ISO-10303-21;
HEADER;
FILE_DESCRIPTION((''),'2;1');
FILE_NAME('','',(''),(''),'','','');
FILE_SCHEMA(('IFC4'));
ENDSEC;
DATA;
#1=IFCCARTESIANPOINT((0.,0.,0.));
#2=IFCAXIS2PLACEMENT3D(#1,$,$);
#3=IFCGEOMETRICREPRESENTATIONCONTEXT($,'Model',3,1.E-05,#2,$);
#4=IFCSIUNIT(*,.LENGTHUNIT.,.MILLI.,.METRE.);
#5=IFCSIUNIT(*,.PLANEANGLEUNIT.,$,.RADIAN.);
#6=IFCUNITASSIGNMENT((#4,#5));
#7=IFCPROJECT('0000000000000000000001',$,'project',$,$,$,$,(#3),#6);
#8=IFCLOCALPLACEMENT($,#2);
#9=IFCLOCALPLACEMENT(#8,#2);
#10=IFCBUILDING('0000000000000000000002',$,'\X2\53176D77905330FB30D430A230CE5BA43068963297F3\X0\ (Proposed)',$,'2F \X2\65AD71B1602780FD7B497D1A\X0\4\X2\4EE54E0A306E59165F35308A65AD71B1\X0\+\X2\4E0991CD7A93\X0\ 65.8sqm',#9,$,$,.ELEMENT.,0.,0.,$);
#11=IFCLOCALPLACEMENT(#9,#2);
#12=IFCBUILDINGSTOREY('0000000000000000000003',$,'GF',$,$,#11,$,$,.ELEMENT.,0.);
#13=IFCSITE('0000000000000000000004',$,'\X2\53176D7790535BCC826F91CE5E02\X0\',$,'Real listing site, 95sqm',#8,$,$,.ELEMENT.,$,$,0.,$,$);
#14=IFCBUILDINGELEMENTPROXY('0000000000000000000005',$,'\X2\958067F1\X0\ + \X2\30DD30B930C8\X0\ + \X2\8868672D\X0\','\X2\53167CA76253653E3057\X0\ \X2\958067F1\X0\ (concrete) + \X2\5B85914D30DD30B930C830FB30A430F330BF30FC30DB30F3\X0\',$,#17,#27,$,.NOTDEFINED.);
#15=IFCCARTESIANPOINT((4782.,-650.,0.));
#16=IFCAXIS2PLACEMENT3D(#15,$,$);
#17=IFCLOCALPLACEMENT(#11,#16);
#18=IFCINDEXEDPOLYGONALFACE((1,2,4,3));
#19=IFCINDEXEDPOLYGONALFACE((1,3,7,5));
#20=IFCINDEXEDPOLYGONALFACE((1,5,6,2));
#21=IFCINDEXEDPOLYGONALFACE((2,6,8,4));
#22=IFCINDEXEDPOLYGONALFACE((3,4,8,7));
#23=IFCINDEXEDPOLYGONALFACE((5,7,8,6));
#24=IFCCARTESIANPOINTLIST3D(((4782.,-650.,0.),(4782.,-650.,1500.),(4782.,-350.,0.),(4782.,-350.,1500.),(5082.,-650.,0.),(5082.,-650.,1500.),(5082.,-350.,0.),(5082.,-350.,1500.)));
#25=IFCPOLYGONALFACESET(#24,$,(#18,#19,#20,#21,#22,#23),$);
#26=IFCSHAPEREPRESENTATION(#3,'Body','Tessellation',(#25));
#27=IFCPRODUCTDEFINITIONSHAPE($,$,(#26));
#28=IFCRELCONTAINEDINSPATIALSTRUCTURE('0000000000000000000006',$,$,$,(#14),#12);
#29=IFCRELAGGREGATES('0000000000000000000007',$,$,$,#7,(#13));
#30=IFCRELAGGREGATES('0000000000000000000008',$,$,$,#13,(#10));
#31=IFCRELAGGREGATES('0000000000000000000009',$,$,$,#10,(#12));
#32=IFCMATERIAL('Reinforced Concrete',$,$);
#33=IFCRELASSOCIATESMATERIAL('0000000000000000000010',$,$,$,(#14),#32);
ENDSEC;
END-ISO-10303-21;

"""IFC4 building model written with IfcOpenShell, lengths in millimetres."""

from ifc_helpers import new_model, si_unit, frame, frame_2d, origin, place, context, project, spatial, rectangle, extrude, material, element, save


model = new_model("IFC4")

# Units and contexts
model_context = context("Model", 3, precision=1e-05, world=origin())
ifc_project = project(units=[si_unit("LENGTHUNIT", "METRE", prefix="MILLI"), si_unit("PLANEANGLEUNIT", "RADIAN")], contexts=[model_context])

# Site, building, storey
site_placement = place(None, origin())
site = spatial("IfcSite", under=ifc_project, at=site_placement, Name="北海道富良野市", ObjectType="Real listing site, 95sqm", CompositionType="ELEMENT", RefElevation=0.0)
building_placement = place(site_placement, origin())
building = spatial("IfcBuilding", under=site, at=building_placement, Name="北海道・ピアノ室と防音 (Proposed)", ObjectType="2F 断熱性能等級4以上の外張り断熱+三重窓 65.8sqm", CompositionType="ELEMENT", ElevationOfRefHeight=0.0, ElevationOfTerrain=0.0)
storey_placement = place(building_placement, origin())
storey = spatial("IfcBuildingStorey", under=building, at=storey_placement, Name="GF", CompositionType="ELEMENT", Elevation=0.0)

# Shared definitions
ifc_material_1 = material(Name="Reinforced Concrete")

# Building element proxy
proxy_placement = place(storey_placement, frame((4782.0, -650.0, 0.0)))
element("IfcBuildingElementProxy", 1, at=proxy_placement, inside=storey, material=ifc_material_1, Name="門柱 + ポスト + 表札", Description="化粧打放し 門柱 (concrete) + 宅配ポスト・インターホン", PredefinedType="NOTDEFINED", context=model_context, shape_type="SweptSolid", body=[
    extrude(rectangle(XDim=300.0, YDim=300.0, at=frame_2d((150.0, 150.0))), frame((4782.0, -650.0, 0.0)), (0.0, 0.0, 1.0), 1500.0),
])

save(model, "model.ifc")
